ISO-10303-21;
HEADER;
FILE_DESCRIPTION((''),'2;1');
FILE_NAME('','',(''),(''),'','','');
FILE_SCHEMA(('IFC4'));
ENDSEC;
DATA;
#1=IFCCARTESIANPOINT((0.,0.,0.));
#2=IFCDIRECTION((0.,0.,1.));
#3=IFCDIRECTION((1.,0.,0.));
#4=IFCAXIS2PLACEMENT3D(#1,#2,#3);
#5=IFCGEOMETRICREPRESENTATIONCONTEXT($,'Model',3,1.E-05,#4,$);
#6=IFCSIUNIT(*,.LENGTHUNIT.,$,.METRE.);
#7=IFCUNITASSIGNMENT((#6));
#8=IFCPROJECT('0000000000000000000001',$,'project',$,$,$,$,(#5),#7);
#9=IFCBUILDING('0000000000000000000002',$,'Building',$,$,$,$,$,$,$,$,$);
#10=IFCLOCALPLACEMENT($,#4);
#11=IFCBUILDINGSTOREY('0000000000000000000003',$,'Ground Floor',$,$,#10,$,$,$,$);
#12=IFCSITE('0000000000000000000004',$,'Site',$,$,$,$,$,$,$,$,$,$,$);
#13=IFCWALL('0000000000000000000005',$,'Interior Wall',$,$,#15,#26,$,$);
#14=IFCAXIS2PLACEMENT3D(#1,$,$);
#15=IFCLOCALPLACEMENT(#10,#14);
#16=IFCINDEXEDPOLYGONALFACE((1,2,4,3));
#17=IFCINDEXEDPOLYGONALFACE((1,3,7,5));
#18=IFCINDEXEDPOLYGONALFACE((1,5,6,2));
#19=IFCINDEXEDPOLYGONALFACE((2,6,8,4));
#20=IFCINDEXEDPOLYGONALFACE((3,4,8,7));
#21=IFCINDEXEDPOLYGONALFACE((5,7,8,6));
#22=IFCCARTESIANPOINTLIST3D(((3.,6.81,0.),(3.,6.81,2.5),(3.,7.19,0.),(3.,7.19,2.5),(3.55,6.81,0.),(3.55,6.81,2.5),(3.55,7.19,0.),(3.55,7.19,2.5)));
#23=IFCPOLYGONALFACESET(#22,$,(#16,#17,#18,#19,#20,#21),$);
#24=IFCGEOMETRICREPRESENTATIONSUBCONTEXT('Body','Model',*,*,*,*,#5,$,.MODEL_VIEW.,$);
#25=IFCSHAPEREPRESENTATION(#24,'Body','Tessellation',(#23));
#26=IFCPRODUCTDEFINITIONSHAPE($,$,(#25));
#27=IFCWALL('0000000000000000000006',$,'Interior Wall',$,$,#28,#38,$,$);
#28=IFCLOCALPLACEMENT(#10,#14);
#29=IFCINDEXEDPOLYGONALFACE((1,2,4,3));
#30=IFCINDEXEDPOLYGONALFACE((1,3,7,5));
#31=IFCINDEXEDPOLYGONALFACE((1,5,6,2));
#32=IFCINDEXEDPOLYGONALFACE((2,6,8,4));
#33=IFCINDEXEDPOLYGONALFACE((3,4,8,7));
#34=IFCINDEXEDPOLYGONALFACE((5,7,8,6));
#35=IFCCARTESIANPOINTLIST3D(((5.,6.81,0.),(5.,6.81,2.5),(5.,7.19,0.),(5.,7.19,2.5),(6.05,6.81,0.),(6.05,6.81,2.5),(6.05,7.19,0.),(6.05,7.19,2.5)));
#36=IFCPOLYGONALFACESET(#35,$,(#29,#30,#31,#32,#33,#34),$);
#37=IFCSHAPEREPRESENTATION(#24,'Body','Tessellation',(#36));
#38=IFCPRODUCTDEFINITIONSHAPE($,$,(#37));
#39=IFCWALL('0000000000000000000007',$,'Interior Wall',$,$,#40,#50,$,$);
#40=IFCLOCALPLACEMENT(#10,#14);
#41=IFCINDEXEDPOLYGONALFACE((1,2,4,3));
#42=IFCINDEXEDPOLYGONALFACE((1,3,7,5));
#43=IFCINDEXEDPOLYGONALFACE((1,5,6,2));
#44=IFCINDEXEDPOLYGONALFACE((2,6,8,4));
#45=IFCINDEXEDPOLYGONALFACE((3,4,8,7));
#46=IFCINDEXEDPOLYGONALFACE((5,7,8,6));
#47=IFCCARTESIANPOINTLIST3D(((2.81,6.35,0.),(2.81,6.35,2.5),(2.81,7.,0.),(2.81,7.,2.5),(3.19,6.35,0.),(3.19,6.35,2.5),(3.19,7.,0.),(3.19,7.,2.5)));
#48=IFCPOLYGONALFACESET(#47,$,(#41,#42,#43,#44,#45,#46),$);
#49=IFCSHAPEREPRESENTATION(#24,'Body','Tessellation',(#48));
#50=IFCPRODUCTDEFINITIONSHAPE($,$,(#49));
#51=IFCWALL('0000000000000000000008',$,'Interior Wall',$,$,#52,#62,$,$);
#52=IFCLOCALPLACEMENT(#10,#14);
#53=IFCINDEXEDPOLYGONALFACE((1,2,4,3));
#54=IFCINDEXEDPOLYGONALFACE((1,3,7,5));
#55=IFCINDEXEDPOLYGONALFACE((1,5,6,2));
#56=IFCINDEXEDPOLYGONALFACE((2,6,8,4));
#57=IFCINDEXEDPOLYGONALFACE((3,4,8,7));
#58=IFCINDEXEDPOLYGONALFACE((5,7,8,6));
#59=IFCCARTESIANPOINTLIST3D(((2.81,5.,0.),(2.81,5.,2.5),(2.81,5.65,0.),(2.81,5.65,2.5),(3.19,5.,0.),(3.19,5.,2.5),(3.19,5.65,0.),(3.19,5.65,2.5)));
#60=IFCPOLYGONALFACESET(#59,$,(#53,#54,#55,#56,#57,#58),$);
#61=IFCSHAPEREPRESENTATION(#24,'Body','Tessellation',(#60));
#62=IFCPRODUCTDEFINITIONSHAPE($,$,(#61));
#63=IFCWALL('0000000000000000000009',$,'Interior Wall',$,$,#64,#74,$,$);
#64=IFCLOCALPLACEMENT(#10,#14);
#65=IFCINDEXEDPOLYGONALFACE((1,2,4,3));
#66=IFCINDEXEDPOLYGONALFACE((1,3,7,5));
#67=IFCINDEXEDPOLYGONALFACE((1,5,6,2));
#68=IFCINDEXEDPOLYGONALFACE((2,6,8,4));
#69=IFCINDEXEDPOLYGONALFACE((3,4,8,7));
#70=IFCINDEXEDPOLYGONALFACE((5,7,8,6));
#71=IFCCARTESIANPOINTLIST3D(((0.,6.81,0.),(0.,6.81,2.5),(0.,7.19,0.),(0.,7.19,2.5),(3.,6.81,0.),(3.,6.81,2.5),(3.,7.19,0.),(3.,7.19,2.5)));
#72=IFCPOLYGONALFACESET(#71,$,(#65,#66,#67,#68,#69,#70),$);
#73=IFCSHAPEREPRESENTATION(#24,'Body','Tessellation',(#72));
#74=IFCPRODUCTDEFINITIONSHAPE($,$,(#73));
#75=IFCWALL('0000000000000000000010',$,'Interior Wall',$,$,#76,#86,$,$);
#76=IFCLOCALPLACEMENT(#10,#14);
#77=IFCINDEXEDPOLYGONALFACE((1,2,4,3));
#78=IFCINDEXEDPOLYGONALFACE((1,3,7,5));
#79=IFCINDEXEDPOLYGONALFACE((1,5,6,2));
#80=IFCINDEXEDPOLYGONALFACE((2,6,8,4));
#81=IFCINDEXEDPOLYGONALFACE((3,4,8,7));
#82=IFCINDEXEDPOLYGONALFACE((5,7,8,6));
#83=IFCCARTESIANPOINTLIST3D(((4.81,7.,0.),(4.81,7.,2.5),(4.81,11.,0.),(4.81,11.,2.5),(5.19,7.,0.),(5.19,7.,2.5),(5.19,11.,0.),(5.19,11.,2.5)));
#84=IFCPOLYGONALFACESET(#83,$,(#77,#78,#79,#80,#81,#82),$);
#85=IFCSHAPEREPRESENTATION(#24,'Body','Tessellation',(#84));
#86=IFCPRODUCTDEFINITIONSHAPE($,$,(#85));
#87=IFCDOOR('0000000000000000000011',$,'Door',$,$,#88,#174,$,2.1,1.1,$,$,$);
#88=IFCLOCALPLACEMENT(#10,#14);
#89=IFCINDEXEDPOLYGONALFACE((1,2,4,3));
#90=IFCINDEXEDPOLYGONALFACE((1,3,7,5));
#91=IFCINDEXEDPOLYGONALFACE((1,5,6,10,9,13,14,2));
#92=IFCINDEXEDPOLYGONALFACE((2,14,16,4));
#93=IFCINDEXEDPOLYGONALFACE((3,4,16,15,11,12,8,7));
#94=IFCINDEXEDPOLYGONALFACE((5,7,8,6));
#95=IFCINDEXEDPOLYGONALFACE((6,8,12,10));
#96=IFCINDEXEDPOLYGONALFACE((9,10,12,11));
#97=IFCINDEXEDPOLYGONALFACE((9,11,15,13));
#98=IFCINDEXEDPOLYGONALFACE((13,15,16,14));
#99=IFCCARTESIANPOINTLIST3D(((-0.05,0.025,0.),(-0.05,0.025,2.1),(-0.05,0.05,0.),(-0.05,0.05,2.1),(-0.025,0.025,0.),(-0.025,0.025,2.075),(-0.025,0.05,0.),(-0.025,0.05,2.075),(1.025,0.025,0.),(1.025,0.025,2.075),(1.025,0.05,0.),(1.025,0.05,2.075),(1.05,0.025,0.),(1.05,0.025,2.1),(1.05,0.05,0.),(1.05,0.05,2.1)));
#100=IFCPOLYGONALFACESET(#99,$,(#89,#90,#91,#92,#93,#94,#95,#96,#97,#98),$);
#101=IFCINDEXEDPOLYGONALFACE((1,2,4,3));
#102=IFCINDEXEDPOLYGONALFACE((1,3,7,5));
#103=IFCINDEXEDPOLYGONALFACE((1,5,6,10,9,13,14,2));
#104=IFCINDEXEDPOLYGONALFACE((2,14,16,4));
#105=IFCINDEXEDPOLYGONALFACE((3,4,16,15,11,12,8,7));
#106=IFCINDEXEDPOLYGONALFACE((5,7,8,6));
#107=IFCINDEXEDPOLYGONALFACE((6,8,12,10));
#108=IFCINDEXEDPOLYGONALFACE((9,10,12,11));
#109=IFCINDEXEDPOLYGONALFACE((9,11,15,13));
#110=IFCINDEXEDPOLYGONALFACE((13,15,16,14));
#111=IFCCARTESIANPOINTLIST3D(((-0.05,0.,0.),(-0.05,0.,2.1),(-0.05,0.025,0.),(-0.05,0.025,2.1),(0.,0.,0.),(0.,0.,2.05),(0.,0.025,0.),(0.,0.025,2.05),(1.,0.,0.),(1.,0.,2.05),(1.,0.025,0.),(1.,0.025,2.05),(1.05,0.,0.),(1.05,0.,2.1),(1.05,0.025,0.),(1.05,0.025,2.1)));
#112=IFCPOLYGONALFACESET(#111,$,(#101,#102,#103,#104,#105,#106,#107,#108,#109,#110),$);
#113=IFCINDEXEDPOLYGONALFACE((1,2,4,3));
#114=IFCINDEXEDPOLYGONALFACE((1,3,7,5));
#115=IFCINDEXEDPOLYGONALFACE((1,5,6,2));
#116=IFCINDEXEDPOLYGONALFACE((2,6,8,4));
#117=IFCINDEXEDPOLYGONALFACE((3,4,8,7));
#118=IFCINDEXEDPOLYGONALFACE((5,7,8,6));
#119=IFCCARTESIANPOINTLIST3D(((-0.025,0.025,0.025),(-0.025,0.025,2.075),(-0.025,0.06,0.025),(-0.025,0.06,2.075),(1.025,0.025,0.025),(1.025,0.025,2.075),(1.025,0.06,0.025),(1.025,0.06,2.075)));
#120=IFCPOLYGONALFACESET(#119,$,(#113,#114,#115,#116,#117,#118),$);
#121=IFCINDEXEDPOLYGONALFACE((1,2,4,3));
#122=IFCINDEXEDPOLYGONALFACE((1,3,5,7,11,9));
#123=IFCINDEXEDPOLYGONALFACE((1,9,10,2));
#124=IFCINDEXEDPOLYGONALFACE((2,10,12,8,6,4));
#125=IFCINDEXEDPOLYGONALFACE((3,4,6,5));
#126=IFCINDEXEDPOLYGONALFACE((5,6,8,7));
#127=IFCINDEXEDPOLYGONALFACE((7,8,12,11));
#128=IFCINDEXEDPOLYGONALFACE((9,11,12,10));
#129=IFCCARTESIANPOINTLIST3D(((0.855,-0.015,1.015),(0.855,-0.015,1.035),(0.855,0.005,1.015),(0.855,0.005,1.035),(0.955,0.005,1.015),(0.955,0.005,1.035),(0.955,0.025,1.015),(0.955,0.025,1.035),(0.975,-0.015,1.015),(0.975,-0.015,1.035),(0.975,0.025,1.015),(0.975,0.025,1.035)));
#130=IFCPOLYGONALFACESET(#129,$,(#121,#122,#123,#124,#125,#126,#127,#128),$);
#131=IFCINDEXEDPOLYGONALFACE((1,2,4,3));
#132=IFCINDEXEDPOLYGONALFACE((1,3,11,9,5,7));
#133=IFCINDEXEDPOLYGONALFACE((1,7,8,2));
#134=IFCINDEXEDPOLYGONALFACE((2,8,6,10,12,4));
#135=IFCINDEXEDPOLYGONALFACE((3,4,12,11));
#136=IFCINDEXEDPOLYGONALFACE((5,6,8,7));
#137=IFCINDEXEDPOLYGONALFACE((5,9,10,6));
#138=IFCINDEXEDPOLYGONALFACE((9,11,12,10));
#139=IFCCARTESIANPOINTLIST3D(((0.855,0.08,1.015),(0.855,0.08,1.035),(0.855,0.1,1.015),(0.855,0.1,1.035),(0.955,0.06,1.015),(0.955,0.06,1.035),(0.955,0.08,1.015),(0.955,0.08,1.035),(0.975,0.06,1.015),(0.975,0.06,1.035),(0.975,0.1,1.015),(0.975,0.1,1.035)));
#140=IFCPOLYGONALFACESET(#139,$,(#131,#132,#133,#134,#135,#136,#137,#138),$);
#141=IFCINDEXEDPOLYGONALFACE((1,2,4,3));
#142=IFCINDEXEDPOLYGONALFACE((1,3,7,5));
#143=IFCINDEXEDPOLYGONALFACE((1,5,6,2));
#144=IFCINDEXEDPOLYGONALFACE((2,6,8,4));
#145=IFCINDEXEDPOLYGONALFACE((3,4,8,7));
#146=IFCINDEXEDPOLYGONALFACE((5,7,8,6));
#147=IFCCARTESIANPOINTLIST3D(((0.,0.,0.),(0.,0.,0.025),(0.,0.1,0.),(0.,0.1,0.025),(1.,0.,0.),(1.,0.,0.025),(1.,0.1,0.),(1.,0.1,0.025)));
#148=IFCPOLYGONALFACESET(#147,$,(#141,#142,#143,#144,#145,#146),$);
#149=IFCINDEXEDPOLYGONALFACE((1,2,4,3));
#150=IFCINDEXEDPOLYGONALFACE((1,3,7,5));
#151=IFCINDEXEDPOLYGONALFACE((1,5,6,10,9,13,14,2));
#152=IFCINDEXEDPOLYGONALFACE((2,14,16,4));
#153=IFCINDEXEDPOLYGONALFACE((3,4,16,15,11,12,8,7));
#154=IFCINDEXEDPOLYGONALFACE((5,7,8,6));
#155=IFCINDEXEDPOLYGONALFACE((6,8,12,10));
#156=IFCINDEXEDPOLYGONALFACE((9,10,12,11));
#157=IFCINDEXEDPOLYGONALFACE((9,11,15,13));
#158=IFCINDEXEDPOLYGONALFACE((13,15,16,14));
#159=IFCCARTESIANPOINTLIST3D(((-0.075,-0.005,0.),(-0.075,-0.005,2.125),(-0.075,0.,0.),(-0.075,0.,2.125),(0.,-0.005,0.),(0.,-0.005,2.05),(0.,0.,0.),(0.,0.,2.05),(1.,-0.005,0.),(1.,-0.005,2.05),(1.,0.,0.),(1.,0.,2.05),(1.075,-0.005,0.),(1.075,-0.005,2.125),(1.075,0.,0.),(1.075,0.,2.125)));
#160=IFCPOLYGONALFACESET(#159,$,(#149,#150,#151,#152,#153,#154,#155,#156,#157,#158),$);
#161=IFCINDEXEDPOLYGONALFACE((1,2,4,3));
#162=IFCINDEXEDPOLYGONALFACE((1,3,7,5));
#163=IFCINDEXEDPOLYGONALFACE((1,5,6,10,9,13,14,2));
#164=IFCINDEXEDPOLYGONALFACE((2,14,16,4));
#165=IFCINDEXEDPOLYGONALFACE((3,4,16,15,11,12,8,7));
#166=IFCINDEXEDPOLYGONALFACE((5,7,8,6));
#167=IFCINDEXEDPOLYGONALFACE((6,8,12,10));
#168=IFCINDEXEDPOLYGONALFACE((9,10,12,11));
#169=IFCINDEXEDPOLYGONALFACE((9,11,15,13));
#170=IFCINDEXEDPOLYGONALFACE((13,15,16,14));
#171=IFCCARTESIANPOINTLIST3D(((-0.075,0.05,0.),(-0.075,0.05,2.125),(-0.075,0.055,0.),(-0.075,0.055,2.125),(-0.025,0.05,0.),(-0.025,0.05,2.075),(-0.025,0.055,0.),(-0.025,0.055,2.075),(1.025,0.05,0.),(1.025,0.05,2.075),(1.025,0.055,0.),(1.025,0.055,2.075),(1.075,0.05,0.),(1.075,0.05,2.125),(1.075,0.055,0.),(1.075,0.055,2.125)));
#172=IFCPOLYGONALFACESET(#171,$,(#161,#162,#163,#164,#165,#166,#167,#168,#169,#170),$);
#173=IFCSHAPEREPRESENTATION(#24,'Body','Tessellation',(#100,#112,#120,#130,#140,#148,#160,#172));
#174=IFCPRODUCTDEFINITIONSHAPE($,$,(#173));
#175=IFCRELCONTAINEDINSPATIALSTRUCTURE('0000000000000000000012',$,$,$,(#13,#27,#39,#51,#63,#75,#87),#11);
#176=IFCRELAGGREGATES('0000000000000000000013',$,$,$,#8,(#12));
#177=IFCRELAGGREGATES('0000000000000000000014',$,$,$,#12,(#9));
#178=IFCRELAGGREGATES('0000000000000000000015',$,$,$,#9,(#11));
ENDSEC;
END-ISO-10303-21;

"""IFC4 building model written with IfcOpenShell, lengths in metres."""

from ifc_helpers import new_model, si_unit, frame, origin_with_axes, place, context, subcontext, project, spatial, line, indexed_curve, outline, extrude, element, save


model = new_model("IFC4")

# Units and contexts
model_context = context("Model", 3, precision=1e-05, world=origin_with_axes())
body_context = subcontext(model_context, "Body", "Model", "MODEL_VIEW")
ifc_project = project(units=[si_unit("LENGTHUNIT", "METRE")], contexts=[model_context])

# Site, building, storey
site = spatial("IfcSite", under=ifc_project, Name="Site")
building = spatial("IfcBuilding", under=site, Name="Building")
storey_placement = place(None, origin_with_axes())
storey = spatial("IfcBuildingStorey", under=building, at=storey_placement, Name="Ground Floor")

# Walls
for number, where, z_axis, x_axis, name in (
    (1, (3.55, 7.0, 0.0), (0.0, 0.0, 1.0), (-1.0, 0.0, 0.0), "Interior Wall"),
):
    element("IfcWall", number, at=place(storey_placement, frame(where, z_axis=z_axis, x_axis=x_axis)), inside=storey, Name=name, context=body_context, shape_type="SweptSolid", body=[
        extrude(outline(indexed_curve([(0.0, 0.0), (0.0, 0.38), (0.55, 0.38), (0.55, 0.0), (0.0, 0.0)], self_intersect=False)), frame((0.0, -0.19, 0.0), z_axis=(0.0, 0.0, 1.0), x_axis=(1.0, 0.0, 0.0)), (0.0, 0.0, 1.0), 2.5),
    ])
wall_1_placement = place(storey_placement, frame((6.05, 7.0, 0.0), z_axis=(0.0, 0.0, 1.0), x_axis=(-1.0, 0.0, 0.0)))
element("IfcWall", 2, at=wall_1_placement, inside=storey, Name="Interior Wall", context=body_context, shape_type="SweptSolid", body=[
    extrude(outline(indexed_curve([(0.0, 0.0), (0.0, 0.38), (1.05, 0.38), (1.05, 0.0), (0.0, 0.0)], self_intersect=False)), frame((0.0, -0.19, 0.0), z_axis=(0.0, 0.0, 1.0), x_axis=(1.0, 0.0, 0.0)), (0.0, 0.0, 1.0), 2.5),
])
for number, where, z_axis, x_axis, name in (
    (3, (3.0, 7.0, 0.0), (0.0, 0.0, 1.0), (0.0, -1.0, 0.0), "Interior Wall"),
    (4, (3.0, 5.65, 0.0), (0.0, 0.0, 1.0), (0.0, -1.0, 0.0), "Interior Wall"),
):
    element("IfcWall", number, at=place(storey_placement, frame(where, z_axis=z_axis, x_axis=x_axis)), inside=storey, Name=name, context=body_context, shape_type="SweptSolid", body=[
        extrude(outline(indexed_curve([(0.0, 0.0), (0.0, 0.38), (0.65, 0.38), (0.65, 0.0), (0.0, 0.0)], self_intersect=False)), frame((0.0, -0.19, 0.0), z_axis=(0.0, 0.0, 1.0), x_axis=(1.0, 0.0, 0.0)), (0.0, 0.0, 1.0), 2.5),
    ])
wall_2_placement = place(storey_placement, frame((3.0, 7.0, 0.0), z_axis=(0.0, 0.0, 1.0), x_axis=(-1.0, 0.0, 0.0)))
element("IfcWall", 5, at=wall_2_placement, inside=storey, Name="Interior Wall", context=body_context, shape_type="SweptSolid", body=[
    extrude(outline(indexed_curve([(0.0, 0.0), (0.0, 0.38), (3.0, 0.38), (3.0, 0.0), (0.0, 0.0)], self_intersect=False)), frame((0.0, -0.19, 0.0), z_axis=(0.0, 0.0, 1.0), x_axis=(1.0, 0.0, 0.0)), (0.0, 0.0, 1.0), 2.5),
])
wall_3_placement = place(storey_placement, frame((5.0, 7.0, 0.0), z_axis=(0.0, 0.0, 1.0), x_axis=(0.0, 1.0, 0.0)))
element("IfcWall", 6, at=wall_3_placement, inside=storey, Name="Interior Wall", context=body_context, shape_type="SweptSolid", body=[
    extrude(outline(indexed_curve([(0.0, 0.0), (0.0, 0.38), (4.0, 0.38), (4.0, 0.0), (0.0, 0.0)], self_intersect=False)), frame((0.0, -0.19, 0.0), z_axis=(0.0, 0.0, 1.0), x_axis=(1.0, 0.0, 0.0)), (0.0, 0.0, 1.0), 2.5),
])

# Door
door_1_placement = place(storey_placement, frame((-0.05, 0.0, 0.0), z_axis=(0.0, 0.0, 1.0), x_axis=(1.0, 0.0, 0.0)))
element("IfcDoor", 7, at=door_1_placement, inside=storey, Name="Door", OverallHeight=2.1, OverallWidth=1.1, context=body_context, shape_type="SweptSolid", body=[
    extrude(outline(indexed_curve([(0.0, 0.0), (0.0, 2.1), (1.1, 2.1), (1.1, 0.0), (1.075, 0.0), (1.075, 2.075), (0.025, 2.075), (0.025, 0.0)], segments=[line(1, 2, 3, 4, 5, 6, 7, 8, 1)])), frame((0.0, 0.025, 0.0), z_axis=(0.0, -1.0, 0.0), x_axis=(1.0, 0.0, 0.0)), (0.0, 0.0, -1.0), 0.025),
    extrude(outline(indexed_curve([(0.0, 0.0), (0.0, 2.1), (1.1, 2.1), (1.1, 0.0), (1.05, 0.0), (1.05, 2.05), (0.05, 2.05), (0.05, 0.0)], segments=[line(1, 2, 3, 4, 5, 6, 7, 8, 1)])), frame((0.0, 0.0, 0.0), z_axis=(0.0, -1.0, 0.0), x_axis=(1.0, 0.0, 0.0)), (0.0, 0.0, -1.0), 0.025),
    extrude(outline(indexed_curve([(0.0, 0.0), (1.05, 0.0), (1.05, 0.035), (0.0, 0.035)], segments=[line(1, 2, 3, 4, 1)])), frame((0.025, 0.025, 0.025), z_axis=(0.0, 0.0, 1.0), x_axis=(1.0, 0.0, 0.0)), (0.0, 0.0, 1.0), 2.05),
    extrude(outline(indexed_curve([(0.0, 0.0), (0.0, -0.04), (-0.12, -0.04), (-0.12, -0.02), (-0.02, -0.02), (-0.02, 0.0)], segments=[line(1, 2, 3, 4, 5, 6, 1)])), frame((1.025, 0.025, 1.015), z_axis=(0.0, 0.0, 1.0), x_axis=(1.0, 0.0, 0.0)), (0.0, 0.0, 1.0), 0.02),
    extrude(outline(indexed_curve([(0.0, 0.0), (0.0, 0.04), (-0.12, 0.04), (-0.12, 0.02), (-0.02, 0.02), (-0.02, 0.0)], segments=[line(1, 2, 3, 4, 5, 6, 1)])), frame((1.025, 0.06, 1.015), z_axis=(0.0, 0.0, 1.0), x_axis=(1.0, 0.0, 0.0)), (0.0, 0.0, 1.0), 0.02),
    extrude(outline(indexed_curve([(0.0, 0.0), (1.0, 0.0), (1.0, 0.1), (0.0, 0.1)], segments=[line(1, 2, 3, 4, 1)])), frame((0.05, 0.0, 0.0), z_axis=(0.0, 0.0, 1.0), x_axis=(1.0, 0.0, 0.0)), (0.0, 0.0, 1.0), 0.025),
    extrude(outline(indexed_curve([(0.0, 0.0), (0.0, 2.125), (1.15, 2.125), (1.15, 0.0), (1.075, 0.0), (1.075, 2.05), (0.075, 2.05), (0.075, 0.0)], segments=[line(1, 2, 3, 4, 5, 6, 7, 8, 1)])), frame((-0.025, -0.005, 0.0), z_axis=(0.0, -1.0, 0.0), x_axis=(1.0, 0.0, 0.0)), (0.0, 0.0, -1.0), 0.005),
    extrude(outline(indexed_curve([(0.0, 0.0), (0.0, 2.125), (1.15, 2.125), (1.15, 0.0), (1.1, 0.0), (1.1, 2.075), (0.05, 2.075), (0.05, 0.0)], segments=[line(1, 2, 3, 4, 5, 6, 7, 8, 1)])), frame((-0.025, 0.05, 0.0), z_axis=(0.0, -1.0, 0.0), x_axis=(1.0, 0.0, 0.0)), (0.0, 0.0, -1.0), 0.005),
])

save(model, "model.ifc")
